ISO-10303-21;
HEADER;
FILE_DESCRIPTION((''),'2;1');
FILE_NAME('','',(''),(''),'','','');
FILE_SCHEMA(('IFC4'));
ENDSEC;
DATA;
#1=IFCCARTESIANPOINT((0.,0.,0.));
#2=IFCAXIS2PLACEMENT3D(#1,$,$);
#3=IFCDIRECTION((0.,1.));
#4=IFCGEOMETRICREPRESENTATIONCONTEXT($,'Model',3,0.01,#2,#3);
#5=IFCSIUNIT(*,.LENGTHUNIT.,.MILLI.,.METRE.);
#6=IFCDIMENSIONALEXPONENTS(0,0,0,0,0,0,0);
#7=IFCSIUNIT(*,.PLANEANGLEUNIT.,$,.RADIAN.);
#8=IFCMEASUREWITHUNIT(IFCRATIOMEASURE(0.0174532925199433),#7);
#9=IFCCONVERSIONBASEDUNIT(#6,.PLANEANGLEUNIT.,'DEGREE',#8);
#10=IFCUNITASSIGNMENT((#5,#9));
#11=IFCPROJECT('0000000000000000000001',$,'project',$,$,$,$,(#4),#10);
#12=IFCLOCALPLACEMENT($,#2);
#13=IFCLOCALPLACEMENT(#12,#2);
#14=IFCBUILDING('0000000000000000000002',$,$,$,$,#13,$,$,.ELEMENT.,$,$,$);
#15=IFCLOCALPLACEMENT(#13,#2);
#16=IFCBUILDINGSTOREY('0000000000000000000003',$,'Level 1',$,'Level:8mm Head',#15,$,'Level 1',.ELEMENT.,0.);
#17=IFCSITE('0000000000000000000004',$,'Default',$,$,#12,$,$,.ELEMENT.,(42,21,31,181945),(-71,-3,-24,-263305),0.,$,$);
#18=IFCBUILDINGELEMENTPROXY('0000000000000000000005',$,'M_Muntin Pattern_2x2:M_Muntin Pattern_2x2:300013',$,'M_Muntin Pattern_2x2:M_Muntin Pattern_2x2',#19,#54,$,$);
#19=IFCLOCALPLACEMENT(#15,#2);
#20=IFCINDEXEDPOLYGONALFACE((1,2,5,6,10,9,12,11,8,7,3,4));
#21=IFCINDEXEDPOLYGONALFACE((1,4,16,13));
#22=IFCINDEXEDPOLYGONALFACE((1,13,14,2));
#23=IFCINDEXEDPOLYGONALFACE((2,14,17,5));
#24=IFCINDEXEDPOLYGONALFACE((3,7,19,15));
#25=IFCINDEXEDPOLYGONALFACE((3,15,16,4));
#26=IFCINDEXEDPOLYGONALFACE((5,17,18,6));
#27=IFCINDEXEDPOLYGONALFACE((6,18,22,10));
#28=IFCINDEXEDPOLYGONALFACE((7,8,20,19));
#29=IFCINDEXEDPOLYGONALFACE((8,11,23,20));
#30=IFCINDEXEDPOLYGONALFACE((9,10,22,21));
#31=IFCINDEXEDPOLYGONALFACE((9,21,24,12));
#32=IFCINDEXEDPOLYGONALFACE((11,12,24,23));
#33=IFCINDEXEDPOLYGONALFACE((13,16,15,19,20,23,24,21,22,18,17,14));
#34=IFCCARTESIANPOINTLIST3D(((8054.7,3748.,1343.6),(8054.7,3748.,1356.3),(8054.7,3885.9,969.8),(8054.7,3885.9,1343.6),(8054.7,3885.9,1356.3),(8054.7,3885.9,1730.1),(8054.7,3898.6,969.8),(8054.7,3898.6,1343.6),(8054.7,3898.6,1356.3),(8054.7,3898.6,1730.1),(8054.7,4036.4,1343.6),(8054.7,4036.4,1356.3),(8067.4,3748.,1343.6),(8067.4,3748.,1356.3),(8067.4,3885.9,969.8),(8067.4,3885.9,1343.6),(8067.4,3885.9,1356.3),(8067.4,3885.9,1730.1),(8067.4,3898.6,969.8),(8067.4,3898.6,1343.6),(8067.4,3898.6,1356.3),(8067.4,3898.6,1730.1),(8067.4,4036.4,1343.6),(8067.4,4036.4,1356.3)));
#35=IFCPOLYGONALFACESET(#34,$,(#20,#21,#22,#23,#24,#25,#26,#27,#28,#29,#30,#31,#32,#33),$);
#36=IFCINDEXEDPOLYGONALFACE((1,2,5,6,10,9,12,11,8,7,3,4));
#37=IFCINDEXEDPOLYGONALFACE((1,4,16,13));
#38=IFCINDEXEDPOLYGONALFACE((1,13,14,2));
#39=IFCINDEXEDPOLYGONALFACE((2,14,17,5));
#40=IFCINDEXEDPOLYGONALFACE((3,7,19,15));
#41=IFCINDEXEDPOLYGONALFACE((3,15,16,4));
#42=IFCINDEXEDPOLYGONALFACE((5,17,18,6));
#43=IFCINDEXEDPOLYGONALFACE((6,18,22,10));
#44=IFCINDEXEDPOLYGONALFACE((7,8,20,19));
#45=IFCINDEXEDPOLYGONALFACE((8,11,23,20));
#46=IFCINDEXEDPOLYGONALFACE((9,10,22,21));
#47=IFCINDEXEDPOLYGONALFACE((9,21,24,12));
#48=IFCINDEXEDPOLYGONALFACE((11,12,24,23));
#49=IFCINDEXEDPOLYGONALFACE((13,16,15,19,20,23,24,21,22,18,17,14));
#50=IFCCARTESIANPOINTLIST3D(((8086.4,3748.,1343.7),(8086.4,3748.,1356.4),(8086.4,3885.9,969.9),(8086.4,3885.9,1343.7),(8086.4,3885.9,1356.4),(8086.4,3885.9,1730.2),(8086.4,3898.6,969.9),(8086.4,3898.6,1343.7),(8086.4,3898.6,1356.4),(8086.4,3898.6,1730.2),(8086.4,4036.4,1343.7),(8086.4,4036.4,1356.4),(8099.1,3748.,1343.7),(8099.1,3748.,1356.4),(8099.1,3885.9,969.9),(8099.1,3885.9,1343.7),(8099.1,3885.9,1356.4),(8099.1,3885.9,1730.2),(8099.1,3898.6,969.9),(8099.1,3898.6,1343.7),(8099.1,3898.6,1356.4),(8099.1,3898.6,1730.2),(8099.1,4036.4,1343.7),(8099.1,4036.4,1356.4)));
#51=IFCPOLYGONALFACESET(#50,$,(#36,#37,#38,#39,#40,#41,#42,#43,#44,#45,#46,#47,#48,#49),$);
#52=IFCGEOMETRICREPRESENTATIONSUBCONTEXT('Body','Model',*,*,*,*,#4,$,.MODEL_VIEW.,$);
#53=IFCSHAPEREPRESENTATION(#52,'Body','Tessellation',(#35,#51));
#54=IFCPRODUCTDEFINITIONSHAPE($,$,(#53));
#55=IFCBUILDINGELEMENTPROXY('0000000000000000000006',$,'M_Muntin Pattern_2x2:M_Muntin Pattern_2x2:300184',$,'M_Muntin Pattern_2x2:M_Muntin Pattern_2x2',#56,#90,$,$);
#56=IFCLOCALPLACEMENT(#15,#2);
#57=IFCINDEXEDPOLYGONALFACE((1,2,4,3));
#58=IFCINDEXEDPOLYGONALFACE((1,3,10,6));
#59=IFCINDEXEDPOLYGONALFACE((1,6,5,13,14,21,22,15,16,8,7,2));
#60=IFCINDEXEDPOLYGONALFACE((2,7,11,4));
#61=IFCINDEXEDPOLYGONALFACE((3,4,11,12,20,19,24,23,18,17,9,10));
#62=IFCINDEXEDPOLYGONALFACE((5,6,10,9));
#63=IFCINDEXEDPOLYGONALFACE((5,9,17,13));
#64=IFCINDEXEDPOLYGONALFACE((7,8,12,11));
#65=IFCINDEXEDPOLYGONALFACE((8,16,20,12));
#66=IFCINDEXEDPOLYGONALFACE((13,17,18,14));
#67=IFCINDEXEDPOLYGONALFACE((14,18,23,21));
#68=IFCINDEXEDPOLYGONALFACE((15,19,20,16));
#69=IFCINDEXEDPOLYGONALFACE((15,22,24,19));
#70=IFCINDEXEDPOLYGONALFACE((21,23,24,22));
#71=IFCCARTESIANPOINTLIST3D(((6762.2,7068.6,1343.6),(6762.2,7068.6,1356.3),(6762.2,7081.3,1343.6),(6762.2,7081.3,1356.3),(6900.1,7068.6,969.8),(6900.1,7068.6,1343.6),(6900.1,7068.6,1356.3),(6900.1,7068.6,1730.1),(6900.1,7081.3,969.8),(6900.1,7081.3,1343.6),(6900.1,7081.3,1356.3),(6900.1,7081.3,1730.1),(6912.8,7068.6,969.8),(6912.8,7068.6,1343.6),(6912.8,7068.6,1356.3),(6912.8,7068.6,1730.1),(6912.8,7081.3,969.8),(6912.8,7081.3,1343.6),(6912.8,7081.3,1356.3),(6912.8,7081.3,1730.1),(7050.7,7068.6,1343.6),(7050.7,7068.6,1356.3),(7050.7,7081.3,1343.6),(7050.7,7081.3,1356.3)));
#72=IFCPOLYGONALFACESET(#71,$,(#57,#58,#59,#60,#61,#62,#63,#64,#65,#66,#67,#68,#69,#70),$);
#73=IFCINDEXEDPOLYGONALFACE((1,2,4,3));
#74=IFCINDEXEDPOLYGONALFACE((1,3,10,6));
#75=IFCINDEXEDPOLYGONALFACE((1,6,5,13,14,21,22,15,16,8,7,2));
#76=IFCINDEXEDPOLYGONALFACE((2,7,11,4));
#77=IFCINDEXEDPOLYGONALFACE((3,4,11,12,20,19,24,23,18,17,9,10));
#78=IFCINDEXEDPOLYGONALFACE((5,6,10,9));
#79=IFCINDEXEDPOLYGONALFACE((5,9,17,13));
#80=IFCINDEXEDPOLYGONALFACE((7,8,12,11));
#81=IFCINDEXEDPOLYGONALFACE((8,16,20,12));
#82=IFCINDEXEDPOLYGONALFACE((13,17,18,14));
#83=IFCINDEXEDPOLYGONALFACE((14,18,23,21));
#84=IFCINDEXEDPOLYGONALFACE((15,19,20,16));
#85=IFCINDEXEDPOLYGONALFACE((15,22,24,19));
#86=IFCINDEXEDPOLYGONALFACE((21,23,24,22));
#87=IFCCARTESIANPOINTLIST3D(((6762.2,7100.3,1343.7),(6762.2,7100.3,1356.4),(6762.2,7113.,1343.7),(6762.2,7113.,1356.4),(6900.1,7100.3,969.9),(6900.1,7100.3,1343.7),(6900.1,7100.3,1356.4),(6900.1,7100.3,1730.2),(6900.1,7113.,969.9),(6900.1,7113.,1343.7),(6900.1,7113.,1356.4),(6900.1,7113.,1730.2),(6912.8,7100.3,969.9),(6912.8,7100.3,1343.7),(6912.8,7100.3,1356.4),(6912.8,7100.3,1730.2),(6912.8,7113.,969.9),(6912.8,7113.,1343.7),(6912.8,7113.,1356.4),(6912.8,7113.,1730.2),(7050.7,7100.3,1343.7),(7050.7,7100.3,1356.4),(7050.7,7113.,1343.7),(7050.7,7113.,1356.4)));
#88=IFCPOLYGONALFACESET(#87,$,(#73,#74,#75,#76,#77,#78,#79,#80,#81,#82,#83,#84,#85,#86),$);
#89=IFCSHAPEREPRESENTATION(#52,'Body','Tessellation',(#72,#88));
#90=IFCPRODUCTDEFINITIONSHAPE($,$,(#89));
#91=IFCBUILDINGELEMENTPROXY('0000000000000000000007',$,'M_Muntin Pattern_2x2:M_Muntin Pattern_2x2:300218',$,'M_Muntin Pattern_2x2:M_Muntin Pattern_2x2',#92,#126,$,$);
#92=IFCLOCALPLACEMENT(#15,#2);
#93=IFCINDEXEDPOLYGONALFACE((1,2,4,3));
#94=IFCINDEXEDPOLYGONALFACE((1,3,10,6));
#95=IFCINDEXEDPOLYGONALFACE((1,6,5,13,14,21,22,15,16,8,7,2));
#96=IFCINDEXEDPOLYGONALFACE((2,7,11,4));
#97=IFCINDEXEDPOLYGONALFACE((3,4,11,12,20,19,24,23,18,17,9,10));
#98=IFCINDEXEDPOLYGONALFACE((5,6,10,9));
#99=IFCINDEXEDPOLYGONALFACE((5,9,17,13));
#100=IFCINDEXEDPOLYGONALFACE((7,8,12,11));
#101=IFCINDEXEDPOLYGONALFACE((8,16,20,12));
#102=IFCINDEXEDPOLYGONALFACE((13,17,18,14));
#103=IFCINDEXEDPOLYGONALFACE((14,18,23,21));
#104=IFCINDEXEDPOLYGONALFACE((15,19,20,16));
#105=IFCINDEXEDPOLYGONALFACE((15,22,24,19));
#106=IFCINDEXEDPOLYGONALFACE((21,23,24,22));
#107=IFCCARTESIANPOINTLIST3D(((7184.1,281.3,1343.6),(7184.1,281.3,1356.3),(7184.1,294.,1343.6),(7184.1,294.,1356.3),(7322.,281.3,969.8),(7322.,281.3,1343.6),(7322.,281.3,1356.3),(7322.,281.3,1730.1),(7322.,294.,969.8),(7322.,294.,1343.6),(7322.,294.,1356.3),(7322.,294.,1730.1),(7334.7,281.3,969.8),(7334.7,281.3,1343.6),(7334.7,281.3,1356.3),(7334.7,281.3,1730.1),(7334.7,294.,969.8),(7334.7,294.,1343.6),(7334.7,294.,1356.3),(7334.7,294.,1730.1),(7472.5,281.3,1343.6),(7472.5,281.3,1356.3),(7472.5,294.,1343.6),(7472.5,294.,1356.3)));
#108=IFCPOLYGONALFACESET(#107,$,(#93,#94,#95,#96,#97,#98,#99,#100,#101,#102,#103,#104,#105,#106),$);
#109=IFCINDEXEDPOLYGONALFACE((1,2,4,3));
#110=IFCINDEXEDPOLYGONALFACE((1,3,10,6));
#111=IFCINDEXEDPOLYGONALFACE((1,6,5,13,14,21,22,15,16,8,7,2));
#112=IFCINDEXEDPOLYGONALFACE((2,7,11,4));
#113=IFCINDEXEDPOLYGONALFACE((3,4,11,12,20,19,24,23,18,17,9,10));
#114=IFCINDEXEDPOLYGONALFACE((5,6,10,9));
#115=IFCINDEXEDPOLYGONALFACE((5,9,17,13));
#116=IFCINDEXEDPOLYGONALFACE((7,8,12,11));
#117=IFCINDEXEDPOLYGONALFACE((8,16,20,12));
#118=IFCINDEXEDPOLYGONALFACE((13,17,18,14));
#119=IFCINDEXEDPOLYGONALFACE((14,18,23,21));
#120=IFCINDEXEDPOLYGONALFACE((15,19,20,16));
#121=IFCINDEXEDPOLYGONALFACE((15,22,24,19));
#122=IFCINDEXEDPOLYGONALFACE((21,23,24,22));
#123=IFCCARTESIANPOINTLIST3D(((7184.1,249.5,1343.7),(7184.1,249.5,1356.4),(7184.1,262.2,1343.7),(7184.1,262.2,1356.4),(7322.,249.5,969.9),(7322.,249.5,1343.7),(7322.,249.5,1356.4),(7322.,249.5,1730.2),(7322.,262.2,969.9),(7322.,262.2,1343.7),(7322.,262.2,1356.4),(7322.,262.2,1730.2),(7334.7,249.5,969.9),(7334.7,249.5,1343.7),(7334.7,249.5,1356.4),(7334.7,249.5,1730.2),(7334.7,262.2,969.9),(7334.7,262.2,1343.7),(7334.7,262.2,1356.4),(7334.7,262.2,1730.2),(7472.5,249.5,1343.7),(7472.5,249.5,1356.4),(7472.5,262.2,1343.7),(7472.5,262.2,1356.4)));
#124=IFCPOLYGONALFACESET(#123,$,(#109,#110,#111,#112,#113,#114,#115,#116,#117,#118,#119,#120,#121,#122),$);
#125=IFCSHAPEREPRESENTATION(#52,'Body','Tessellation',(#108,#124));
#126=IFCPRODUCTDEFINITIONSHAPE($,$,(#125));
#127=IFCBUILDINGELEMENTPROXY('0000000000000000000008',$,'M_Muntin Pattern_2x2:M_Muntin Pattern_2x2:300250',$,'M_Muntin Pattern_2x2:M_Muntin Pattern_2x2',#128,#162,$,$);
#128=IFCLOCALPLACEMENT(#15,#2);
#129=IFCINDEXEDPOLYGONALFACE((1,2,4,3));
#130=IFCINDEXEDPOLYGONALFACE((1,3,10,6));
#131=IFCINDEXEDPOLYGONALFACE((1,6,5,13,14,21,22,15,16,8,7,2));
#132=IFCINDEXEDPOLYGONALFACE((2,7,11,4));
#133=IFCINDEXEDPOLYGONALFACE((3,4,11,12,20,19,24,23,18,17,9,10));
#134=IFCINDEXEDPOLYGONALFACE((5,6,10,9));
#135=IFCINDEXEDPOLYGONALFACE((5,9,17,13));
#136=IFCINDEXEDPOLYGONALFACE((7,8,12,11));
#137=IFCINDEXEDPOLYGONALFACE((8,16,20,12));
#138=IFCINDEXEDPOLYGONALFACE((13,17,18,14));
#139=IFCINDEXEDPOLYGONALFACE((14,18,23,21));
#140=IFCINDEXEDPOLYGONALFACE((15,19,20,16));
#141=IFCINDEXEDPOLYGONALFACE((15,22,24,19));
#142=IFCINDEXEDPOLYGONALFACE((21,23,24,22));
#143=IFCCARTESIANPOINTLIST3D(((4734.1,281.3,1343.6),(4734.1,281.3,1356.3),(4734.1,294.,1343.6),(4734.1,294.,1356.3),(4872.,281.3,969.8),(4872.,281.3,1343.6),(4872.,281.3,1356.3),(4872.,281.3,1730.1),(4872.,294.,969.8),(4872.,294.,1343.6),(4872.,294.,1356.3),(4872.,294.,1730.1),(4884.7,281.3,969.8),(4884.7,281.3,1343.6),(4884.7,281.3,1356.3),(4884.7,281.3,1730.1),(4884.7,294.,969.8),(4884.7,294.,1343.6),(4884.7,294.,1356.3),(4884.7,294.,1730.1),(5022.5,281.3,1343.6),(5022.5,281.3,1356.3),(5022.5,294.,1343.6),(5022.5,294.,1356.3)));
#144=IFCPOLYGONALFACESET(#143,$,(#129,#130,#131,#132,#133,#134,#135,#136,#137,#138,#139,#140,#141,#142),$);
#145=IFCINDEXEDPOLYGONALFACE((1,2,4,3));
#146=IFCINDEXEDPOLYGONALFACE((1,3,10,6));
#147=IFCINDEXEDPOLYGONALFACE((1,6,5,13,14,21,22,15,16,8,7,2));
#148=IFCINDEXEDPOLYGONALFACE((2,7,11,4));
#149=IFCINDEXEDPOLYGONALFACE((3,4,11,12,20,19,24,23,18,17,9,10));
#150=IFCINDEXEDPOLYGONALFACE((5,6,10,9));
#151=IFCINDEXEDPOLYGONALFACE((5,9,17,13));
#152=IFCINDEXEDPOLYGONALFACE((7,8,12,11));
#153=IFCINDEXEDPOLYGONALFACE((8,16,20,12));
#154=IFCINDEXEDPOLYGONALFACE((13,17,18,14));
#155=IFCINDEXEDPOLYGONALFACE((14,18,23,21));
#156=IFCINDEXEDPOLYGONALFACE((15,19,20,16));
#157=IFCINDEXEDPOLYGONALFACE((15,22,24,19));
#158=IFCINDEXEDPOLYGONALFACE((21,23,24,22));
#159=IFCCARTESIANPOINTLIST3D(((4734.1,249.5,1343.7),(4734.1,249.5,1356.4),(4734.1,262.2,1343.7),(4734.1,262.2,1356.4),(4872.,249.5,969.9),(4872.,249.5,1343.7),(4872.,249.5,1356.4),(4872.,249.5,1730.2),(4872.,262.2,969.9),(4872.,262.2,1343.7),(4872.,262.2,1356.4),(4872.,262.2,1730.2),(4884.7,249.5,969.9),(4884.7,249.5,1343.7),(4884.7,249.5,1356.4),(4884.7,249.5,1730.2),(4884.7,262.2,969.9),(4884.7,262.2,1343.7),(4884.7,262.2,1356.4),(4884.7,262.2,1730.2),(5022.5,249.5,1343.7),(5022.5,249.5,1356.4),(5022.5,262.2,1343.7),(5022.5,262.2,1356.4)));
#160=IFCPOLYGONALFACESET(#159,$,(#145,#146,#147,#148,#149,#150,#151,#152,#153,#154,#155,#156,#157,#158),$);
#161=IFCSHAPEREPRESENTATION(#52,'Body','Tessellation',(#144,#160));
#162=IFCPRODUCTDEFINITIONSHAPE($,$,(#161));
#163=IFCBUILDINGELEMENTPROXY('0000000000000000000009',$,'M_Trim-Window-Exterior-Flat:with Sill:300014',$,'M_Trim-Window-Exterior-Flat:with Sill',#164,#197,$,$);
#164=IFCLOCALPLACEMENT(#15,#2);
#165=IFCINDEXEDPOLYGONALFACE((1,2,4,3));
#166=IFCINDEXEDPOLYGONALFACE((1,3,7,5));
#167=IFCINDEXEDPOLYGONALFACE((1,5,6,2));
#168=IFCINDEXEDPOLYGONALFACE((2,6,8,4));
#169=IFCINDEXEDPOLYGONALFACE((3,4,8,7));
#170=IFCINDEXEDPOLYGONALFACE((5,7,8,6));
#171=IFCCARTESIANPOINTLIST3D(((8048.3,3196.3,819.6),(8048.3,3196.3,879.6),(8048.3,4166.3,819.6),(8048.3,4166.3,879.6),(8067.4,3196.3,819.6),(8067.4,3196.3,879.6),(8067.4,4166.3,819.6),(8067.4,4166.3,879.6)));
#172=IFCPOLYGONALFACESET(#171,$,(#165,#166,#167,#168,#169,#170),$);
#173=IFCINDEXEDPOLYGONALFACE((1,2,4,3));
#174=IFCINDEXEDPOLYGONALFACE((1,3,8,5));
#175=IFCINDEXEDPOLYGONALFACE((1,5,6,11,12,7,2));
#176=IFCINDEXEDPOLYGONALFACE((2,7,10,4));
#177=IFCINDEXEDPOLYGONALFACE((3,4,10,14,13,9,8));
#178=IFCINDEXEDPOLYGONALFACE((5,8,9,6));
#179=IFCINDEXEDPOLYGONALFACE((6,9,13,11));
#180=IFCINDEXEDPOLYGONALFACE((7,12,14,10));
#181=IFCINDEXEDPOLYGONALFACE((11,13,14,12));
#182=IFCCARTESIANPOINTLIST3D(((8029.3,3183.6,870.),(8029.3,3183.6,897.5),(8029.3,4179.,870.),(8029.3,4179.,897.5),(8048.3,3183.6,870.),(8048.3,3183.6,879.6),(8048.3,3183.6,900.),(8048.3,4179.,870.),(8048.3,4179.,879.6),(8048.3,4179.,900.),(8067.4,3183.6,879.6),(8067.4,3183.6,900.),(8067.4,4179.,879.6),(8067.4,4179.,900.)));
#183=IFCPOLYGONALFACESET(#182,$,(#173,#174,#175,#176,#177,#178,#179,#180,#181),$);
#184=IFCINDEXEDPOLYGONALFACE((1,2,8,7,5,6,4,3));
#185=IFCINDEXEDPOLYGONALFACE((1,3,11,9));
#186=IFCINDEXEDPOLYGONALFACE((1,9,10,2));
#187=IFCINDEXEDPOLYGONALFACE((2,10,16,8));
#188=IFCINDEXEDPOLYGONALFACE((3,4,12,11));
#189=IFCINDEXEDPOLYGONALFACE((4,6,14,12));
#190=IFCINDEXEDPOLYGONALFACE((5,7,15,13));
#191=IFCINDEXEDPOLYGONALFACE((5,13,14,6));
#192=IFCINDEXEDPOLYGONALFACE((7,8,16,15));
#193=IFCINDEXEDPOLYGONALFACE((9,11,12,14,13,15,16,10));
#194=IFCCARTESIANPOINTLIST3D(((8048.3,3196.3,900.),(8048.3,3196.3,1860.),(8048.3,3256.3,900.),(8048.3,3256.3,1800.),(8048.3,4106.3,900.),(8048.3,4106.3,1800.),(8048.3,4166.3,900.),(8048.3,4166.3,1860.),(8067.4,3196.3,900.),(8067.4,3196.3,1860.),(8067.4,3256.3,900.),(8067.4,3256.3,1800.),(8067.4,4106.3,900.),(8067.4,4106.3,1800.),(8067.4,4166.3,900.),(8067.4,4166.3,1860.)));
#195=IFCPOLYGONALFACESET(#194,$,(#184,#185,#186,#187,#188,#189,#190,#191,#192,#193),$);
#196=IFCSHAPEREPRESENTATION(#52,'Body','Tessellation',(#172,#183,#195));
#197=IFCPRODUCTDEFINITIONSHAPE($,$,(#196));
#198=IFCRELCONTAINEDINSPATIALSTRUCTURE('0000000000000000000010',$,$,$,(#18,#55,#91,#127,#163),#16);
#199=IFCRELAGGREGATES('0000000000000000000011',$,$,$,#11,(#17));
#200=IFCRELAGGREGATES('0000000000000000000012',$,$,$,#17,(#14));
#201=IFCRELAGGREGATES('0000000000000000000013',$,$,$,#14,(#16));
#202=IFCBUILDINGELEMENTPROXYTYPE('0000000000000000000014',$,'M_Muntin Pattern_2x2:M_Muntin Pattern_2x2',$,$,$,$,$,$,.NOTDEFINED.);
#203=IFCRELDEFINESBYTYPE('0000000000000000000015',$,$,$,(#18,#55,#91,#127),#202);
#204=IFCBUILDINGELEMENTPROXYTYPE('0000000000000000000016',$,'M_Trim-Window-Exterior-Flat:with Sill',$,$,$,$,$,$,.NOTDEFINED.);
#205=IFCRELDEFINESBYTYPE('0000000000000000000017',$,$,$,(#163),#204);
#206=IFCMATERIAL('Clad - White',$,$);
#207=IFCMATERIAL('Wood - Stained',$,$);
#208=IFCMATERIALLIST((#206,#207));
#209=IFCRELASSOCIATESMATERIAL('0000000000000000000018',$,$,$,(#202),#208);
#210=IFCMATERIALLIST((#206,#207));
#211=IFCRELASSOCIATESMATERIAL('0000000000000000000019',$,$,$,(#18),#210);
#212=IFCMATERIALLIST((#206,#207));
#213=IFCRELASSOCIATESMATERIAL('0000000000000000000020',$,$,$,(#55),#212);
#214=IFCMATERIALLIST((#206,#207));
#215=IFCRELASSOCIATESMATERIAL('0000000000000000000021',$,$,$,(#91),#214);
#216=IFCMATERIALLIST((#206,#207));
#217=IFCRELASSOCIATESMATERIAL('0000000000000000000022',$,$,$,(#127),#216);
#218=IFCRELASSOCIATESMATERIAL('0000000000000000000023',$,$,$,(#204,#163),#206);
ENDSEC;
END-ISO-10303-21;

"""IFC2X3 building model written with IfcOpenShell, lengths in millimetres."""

from ifc_helpers import new_model, entity, si_unit, converted_unit, direction, frame, frame_2d, origin, place, context, subcontext, project, spatial, polyline, rectangle, outline, extrude, source, transform, mapped, material, material_list, type_object, type_shapes, element, save


model = new_model("IFC2X3")

# Units and contexts
model_context = context("Model", 3, precision=0.01, world=origin(), true_north=direction((0.0, 1.0)))
body_context = subcontext(model_context, "Body", "Model", "MODEL_VIEW")
ifc_project = project(units=[si_unit("LENGTHUNIT", "METRE", prefix="MILLI"), converted_unit("PLANEANGLEUNIT", "DEGREE", entity("IfcRatioMeasure", 0.0174532925199433), si_unit("PLANEANGLEUNIT", "RADIAN"), dimensions=[0, 0, 0, 0, 0, 0, 0])], contexts=[model_context])

# Site, building, storey
site_placement = place(None, origin())
site = spatial("IfcSite", under=ifc_project, at=site_placement, Name="Default", CompositionType="ELEMENT", RefLatitude=(42, 21, 31, 181945), RefLongitude=(-71, -3, -24, -263305), RefElevation=0.0)
building_placement = place(site_placement, origin())
building = spatial("IfcBuilding", under=site, at=building_placement, CompositionType="ELEMENT")
storey_placement = place(building_placement, origin())
storey = spatial("IfcBuildingStorey", under=building, at=storey_placement, Name="Level 1", ObjectType="Level:8mm Head", LongName="Level 1", CompositionType="ELEMENT", Elevation=0.0)

# Building element proxies
ifc_material_1 = material(Name="Clad - White")
ifc_material_2 = material(Name="Wood - Stained")
ifc_material_list_1 = material_list([ifc_material_1, ifc_material_2])
ifc_material_list_2 = material_list([ifc_material_1, ifc_material_2])
building_element_proxy_type_1 = type_object("IfcBuildingElementProxyType", Name="M_Muntin Pattern_2x2:M_Muntin Pattern_2x2", PredefinedType="NOTDEFINED", material=ifc_material_list_2)
shared_shape_1 = source(origin(), body_context, "Body", "SweptSolid", [
    extrude(outline(polyline([(6.4, -6.4), (380.1, -6.4), (380.1, 6.3), (6.4, 6.3), (6.4, 144.2), (-6.3, 144.2), (-6.3, 6.3), (-380.2, 6.3), (-380.2, -6.4), (-6.3, -6.4), (-6.3, -144.2), (6.4, -144.2), (6.4, -6.4)])), frame((0.0, -22.2, 380.1), z_axis=(0.0, 1.0, 0.0), x_axis=(0.0, 0.0, 1.0)), (0.0, 0.0, 1.0), 12.7),
    extrude(outline(polyline([(6.4, -6.4), (380.2, -6.4), (380.2, 6.3), (6.4, 6.3), (6.4, 144.2), (-6.3, 144.2), (-6.3, 6.3), (-380.2, 6.3), (-380.2, -6.4), (-6.3, -6.4), (-6.3, -144.2), (6.4, -144.2), (6.4, -6.4)])), frame((0.0, 9.5, 380.2), z_axis=(0.0, 1.0, 0.0), x_axis=(0.0, 0.0, 1.0)), (0.0, 0.0, 1.0), 12.7),
])
type_shapes(building_element_proxy_type_1, [shared_shape_1])
proxy_1_placement = place(storey_placement, frame((8076.9, 3892.2, 969.9), z_axis=(0.0, 0.0, 1.0), x_axis=(0.0, -1.0, 0.0)))
element("IfcBuildingElementProxy", 1, at=proxy_1_placement, inside=storey, type_object=building_element_proxy_type_1, material=ifc_material_list_1, Name="M_Muntin Pattern_2x2:M_Muntin Pattern_2x2:300013", ObjectType="M_Muntin Pattern_2x2:M_Muntin Pattern_2x2", context=body_context, shape_type="MappedRepresentation", body=[
    mapped(shared_shape_1, transform((0.0, 0.0, 0.0), scale=1.0)),
])
ifc_material_list_3 = material_list([ifc_material_1, ifc_material_2])
proxy_2_placement = place(storey_placement, frame((6906.5, 7090.8, 969.9)))
element("IfcBuildingElementProxy", 2, at=proxy_2_placement, inside=storey, type_object=building_element_proxy_type_1, material=ifc_material_list_3, Name="M_Muntin Pattern_2x2:M_Muntin Pattern_2x2:300184", ObjectType="M_Muntin Pattern_2x2:M_Muntin Pattern_2x2", context=body_context, shape_type="MappedRepresentation", body=[
    mapped(shared_shape_1, transform((0.0, 0.0, 0.0), scale=1.0)),
])
ifc_material_list_4 = material_list([ifc_material_1, ifc_material_2])
proxy_3_placement = place(storey_placement, frame((7328.3, 271.8, 969.9), z_axis=(0.0, 0.0, 1.0), x_axis=(-1.0, 0.0, 0.0)))
element("IfcBuildingElementProxy", 3, at=proxy_3_placement, inside=storey, type_object=building_element_proxy_type_1, material=ifc_material_list_4, Name="M_Muntin Pattern_2x2:M_Muntin Pattern_2x2:300218", ObjectType="M_Muntin Pattern_2x2:M_Muntin Pattern_2x2", context=body_context, shape_type="MappedRepresentation", body=[
    mapped(shared_shape_1, transform((0.0, 0.0, 0.0), scale=1.0)),
])
ifc_material_list_5 = material_list([ifc_material_1, ifc_material_2])
proxy_4_placement = place(storey_placement, frame((4878.3, 271.8, 969.9), z_axis=(0.0, 0.0, 1.0), x_axis=(-1.0, 0.0, 0.0)))
element("IfcBuildingElementProxy", 4, at=proxy_4_placement, inside=storey, type_object=building_element_proxy_type_1, material=ifc_material_list_5, Name="M_Muntin Pattern_2x2:M_Muntin Pattern_2x2:300250", ObjectType="M_Muntin Pattern_2x2:M_Muntin Pattern_2x2", context=body_context, shape_type="MappedRepresentation", body=[
    mapped(shared_shape_1, transform((0.0, 0.0, 0.0), scale=1.0)),
])
building_element_proxy_type_2 = type_object("IfcBuildingElementProxyType", Name="M_Trim-Window-Exterior-Flat:with Sill", PredefinedType="NOTDEFINED", material=ifc_material_1)
shared_shape_2 = source(origin(), body_context, "Body", "SweptSolid", [
    extrude(rectangle(XDim=970.0, YDim=60.0, at=frame_2d((0.0, 0.0), x_axis=(1.0, 0.0))), frame((0.0, -950.4, 0.0), z_axis=(0.0, 0.0, 1.0), x_axis=(-1.0, 0.0, 0.0)), (0.0, 0.0, 1.0), 19.1),
    extrude(outline(polyline([(-19.0, -15.2), (0.0, -15.2), (0.0, -5.7), (19.0, -5.7), (19.0, 14.8), (0.0, 14.8), (-19.0, 12.3), (-19.0, -15.2)])), frame((-497.7, -914.8, 19.0), z_axis=(1.0, 0.0, 0.0), x_axis=(0.0, 0.0, -1.0)), (0.0, 0.0, 1.0), 995.4),
    extrude(outline(polyline([(-495.0, -485.0), (465.0, -485.0), (465.0, -425.0), (-435.0, -425.0), (-435.0, 425.0), (465.0, 425.0), (465.0, 485.0), (-495.0, 485.0), (-495.0, -485.0)])), frame((0.0, -435.0, 0.0), z_axis=(0.0, 0.0, 1.0), x_axis=(0.0, -1.0, 0.0)), (0.0, 0.0, 1.0), 19.1),
])
type_shapes(building_element_proxy_type_2, [shared_shape_2])
for number, where, z_axis, x_axis, name in (
    (5, (8067.4, 3681.3, 1800.0), (-1.0, 0.0, 0.0), (0.0, -1.0, 0.0), "M_Trim-Window-Exterior-Flat:with Sill:300014"),
):
    element("IfcBuildingElementProxy", number, at=place(storey_placement, frame(where, z_axis=z_axis, x_axis=x_axis)), inside=storey, type_object=building_element_proxy_type_2, material=ifc_material_1, Name=name, ObjectType="M_Trim-Window-Exterior-Flat:with Sill", context=body_context, shape_type="MappedRepresentation", body=[
        mapped(shared_shape_2, transform((0.0, 0.0, 0.0), scale=1.0)),
    ])

save(model, "model.ifc")
